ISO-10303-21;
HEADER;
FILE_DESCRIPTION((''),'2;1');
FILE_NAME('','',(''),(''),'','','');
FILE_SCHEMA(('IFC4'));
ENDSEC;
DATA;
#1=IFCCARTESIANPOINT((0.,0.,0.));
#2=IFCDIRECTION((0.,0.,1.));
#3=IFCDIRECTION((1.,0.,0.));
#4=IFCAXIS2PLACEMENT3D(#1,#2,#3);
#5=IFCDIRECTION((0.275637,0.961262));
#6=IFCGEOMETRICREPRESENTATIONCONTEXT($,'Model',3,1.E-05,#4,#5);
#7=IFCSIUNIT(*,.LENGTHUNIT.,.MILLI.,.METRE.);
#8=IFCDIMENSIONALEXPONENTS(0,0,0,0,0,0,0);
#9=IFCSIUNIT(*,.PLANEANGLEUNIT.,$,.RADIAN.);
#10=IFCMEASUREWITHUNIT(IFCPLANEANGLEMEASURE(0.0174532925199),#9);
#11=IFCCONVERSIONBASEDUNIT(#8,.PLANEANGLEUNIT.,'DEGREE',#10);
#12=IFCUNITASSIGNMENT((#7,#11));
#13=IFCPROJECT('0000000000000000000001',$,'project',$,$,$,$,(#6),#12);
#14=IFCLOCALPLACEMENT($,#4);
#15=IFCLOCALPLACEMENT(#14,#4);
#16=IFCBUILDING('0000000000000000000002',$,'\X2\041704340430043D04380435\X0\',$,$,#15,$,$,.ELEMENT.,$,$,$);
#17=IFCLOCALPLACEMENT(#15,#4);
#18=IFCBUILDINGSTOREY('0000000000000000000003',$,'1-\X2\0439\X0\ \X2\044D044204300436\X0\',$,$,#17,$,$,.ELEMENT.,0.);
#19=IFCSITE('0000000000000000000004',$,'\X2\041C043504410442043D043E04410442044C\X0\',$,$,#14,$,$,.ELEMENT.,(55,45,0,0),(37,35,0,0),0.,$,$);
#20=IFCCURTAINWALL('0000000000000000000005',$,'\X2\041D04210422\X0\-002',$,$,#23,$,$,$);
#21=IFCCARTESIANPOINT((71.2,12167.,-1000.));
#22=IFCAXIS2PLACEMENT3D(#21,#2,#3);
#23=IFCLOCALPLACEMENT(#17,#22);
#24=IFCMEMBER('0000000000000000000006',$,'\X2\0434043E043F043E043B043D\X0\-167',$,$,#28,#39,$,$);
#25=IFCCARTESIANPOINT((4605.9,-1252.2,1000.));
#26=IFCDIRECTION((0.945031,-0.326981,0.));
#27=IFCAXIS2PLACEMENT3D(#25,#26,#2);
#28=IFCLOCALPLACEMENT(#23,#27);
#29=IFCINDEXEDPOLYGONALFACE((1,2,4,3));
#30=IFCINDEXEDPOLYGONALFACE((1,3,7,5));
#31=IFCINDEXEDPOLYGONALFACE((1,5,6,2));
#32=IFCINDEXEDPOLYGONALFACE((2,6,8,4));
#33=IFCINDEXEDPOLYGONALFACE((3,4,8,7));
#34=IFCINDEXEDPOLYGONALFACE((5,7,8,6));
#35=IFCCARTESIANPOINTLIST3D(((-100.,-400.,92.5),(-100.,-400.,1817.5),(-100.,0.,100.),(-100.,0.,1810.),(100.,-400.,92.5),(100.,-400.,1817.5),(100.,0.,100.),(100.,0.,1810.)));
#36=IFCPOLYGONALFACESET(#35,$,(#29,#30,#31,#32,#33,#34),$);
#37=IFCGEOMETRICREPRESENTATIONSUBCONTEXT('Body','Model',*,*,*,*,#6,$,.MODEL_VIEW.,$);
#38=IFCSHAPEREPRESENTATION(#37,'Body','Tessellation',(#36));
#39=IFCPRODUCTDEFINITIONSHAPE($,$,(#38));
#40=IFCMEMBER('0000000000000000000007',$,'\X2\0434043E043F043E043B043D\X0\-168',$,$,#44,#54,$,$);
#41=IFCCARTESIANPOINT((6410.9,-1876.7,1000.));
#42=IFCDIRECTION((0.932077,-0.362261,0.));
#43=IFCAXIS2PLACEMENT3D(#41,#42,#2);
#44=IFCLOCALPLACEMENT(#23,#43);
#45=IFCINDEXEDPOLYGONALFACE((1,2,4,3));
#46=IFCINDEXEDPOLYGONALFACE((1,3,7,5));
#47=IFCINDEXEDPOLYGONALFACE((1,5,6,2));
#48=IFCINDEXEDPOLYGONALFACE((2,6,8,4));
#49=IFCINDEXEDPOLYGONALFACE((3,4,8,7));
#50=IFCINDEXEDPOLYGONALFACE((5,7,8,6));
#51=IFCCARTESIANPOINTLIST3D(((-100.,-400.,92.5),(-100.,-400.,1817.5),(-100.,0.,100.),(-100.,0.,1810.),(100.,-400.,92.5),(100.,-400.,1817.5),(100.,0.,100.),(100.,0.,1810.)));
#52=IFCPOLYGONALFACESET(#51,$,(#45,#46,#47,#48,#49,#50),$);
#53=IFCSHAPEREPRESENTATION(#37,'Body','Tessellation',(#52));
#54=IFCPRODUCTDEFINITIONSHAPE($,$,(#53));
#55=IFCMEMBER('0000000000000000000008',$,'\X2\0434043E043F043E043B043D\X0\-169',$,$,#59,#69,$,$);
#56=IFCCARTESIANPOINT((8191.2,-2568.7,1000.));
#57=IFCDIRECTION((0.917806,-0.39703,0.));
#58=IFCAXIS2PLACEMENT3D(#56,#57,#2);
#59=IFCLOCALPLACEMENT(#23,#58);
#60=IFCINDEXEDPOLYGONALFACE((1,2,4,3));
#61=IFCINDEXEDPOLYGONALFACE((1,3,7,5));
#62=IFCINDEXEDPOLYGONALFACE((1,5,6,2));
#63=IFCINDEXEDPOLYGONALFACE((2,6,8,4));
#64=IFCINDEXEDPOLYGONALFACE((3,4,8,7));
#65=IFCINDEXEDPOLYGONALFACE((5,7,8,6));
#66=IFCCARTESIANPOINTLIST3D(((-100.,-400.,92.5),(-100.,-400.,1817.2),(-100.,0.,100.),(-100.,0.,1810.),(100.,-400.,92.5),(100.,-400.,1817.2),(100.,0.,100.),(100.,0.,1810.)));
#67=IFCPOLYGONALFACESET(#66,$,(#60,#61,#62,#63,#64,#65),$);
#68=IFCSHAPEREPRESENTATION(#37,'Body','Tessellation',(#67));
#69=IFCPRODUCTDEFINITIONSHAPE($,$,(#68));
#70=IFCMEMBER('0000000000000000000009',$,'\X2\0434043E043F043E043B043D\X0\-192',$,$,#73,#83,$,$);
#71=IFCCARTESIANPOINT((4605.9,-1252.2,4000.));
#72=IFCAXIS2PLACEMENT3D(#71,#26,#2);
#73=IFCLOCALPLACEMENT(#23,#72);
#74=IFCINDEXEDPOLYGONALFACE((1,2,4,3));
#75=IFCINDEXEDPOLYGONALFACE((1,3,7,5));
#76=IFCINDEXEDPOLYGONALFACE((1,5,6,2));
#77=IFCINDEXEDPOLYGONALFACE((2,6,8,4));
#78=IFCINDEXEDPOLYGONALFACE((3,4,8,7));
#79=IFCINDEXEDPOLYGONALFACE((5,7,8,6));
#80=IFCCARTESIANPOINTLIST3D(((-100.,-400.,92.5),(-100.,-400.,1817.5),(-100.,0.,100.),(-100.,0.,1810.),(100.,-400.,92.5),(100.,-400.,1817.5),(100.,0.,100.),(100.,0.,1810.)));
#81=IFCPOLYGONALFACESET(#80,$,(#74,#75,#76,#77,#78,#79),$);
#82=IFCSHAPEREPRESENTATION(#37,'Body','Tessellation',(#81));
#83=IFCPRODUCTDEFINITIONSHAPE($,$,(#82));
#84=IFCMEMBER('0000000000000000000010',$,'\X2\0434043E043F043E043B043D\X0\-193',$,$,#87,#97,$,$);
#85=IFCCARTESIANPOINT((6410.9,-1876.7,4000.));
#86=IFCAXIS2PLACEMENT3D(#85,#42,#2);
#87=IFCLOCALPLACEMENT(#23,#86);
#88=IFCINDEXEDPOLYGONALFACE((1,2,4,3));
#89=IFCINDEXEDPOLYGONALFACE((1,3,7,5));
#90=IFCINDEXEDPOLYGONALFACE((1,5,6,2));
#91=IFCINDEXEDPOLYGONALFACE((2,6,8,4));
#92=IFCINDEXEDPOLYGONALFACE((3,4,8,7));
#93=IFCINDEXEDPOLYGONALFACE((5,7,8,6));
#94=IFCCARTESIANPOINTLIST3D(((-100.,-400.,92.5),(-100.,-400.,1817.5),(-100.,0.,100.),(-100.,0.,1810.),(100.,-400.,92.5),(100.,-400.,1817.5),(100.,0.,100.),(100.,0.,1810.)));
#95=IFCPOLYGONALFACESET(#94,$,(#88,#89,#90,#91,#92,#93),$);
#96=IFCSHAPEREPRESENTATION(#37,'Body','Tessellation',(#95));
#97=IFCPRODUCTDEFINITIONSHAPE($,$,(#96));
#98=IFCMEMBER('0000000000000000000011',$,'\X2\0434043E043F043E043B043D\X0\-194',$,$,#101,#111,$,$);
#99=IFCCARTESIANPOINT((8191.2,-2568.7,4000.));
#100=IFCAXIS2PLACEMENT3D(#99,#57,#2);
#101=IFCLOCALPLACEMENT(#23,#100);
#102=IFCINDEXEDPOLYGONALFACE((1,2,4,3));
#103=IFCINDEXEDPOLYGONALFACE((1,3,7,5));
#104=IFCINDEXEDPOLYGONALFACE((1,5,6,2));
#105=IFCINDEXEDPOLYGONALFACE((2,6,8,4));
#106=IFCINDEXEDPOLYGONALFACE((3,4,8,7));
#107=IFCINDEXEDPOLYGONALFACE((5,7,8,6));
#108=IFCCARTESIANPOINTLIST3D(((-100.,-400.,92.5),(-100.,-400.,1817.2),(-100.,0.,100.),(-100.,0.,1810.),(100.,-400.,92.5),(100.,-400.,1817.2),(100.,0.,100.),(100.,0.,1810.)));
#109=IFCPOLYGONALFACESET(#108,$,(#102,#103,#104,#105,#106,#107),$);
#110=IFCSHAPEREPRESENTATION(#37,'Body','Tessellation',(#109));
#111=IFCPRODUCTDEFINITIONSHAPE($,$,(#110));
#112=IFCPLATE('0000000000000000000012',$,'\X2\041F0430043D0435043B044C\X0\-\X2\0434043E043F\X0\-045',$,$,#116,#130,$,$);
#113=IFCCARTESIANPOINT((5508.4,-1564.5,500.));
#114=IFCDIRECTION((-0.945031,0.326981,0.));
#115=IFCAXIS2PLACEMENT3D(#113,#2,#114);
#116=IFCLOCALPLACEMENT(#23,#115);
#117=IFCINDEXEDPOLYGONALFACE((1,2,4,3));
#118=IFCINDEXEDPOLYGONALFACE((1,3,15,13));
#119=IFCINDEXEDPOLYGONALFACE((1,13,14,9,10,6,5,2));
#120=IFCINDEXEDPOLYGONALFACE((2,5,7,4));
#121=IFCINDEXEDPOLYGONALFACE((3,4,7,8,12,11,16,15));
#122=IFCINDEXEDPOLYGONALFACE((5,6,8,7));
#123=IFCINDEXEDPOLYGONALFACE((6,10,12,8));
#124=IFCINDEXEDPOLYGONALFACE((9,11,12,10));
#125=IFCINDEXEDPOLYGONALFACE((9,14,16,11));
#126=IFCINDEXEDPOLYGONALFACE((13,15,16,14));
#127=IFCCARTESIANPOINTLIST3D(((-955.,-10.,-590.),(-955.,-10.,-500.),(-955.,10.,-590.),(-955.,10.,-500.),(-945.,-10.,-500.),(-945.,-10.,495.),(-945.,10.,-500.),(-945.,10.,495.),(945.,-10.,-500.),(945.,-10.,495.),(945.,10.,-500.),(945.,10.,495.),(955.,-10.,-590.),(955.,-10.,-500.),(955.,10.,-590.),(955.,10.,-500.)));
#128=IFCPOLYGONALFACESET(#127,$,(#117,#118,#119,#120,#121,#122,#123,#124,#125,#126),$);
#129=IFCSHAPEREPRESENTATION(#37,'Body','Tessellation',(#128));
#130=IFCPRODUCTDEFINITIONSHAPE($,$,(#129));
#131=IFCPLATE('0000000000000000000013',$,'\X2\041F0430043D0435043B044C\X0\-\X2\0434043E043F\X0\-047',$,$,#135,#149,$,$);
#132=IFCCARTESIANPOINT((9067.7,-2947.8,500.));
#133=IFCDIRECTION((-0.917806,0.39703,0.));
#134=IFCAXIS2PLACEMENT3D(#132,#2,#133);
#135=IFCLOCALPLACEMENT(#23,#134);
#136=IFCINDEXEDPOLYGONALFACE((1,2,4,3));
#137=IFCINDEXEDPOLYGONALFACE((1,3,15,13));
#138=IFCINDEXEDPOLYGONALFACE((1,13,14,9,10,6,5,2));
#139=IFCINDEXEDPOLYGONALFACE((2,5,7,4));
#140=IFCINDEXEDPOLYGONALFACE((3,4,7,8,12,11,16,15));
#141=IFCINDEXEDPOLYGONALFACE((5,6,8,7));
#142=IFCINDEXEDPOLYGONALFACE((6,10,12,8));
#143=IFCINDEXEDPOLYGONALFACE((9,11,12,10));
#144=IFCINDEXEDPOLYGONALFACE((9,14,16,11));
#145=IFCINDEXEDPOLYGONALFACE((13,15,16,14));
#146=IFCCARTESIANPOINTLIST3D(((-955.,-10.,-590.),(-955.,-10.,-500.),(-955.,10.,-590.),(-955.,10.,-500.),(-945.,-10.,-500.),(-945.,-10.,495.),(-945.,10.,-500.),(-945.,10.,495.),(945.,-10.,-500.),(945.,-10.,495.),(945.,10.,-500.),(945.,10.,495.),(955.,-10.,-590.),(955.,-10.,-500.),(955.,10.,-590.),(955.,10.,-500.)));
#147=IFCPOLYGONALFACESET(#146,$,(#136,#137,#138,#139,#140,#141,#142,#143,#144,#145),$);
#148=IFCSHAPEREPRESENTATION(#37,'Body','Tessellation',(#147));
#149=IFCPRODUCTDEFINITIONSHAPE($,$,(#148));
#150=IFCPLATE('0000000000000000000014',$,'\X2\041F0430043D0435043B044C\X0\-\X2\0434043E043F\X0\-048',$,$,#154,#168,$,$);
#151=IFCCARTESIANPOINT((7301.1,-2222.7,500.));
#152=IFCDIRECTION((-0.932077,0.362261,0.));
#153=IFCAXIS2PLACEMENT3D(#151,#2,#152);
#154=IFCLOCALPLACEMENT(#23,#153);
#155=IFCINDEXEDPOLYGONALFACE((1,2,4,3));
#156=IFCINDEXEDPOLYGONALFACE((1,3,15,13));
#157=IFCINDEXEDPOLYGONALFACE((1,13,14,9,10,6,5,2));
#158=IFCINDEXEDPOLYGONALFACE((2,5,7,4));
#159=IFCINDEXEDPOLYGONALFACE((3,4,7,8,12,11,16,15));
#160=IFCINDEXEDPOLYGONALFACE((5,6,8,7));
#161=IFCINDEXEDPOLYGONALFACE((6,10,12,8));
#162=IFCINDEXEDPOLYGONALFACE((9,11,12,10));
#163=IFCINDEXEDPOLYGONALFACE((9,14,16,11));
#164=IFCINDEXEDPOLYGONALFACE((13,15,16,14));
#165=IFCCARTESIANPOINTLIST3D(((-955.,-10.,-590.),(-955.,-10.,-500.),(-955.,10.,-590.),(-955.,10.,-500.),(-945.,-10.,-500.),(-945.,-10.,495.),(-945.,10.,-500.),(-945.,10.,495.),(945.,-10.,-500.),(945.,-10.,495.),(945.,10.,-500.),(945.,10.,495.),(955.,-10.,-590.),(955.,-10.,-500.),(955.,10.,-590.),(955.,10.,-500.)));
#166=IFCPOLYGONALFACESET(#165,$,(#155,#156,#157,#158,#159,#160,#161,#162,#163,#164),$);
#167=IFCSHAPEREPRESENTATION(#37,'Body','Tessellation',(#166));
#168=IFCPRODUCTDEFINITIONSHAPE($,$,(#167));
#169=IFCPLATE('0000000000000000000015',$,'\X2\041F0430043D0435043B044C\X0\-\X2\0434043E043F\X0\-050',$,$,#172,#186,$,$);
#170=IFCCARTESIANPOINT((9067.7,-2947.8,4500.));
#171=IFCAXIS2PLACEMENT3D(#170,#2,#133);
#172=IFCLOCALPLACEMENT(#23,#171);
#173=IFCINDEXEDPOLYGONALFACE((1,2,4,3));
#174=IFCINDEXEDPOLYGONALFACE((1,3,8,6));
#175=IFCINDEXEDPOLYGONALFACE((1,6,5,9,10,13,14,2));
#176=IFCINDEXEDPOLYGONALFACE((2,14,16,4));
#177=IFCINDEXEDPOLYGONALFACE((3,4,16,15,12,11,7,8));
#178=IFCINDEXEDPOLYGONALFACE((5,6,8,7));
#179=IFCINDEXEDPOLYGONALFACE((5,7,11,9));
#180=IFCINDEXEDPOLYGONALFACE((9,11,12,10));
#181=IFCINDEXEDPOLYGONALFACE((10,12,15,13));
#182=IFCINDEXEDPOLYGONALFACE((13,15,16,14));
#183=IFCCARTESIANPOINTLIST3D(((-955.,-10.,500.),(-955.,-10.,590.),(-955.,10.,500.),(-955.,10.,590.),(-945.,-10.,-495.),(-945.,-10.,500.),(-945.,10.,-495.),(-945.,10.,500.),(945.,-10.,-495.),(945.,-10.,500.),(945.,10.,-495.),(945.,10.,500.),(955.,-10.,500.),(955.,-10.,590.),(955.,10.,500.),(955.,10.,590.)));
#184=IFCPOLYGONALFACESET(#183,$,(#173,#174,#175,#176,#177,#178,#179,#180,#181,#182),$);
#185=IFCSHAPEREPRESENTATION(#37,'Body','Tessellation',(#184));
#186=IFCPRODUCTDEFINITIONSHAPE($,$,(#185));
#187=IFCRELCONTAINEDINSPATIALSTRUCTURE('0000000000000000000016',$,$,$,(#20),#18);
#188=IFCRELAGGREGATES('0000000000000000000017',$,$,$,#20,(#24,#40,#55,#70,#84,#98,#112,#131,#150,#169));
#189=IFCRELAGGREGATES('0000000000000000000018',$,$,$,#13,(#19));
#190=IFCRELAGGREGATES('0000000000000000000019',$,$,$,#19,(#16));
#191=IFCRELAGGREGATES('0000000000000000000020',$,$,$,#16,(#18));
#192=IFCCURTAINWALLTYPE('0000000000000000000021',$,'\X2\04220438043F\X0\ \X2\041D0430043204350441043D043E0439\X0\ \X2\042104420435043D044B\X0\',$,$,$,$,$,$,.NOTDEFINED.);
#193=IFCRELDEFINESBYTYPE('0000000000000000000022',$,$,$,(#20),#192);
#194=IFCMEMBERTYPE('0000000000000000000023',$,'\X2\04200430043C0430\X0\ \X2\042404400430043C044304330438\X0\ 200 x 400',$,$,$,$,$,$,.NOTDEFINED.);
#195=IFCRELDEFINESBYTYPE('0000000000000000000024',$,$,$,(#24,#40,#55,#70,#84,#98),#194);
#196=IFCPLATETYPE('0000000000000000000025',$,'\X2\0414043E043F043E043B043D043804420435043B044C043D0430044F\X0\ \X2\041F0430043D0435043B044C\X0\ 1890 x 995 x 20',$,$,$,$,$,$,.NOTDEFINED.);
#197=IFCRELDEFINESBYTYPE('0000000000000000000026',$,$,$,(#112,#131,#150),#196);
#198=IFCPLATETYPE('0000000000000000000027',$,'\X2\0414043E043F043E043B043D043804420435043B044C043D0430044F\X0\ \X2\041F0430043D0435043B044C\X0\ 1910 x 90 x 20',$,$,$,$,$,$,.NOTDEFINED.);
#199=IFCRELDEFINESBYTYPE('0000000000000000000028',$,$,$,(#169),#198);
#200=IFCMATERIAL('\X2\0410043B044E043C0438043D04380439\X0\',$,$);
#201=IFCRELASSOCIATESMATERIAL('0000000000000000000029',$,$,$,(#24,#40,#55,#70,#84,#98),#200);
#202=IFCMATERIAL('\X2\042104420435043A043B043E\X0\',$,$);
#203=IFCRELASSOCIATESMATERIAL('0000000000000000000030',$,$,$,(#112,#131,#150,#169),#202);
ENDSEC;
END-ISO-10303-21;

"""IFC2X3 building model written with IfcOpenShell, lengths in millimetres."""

from ifc_helpers import new_model, entity, si_unit, converted_unit, direction, frame, origin_with_axes, place, context, subcontext, project, spatial, polyline, outline, extrude, clip, halfspace, material, type_object, element, aggregate, save


model = new_model("IFC2X3")

# Units and contexts
model_context = context("Model", 3, precision=1e-05, world=origin_with_axes(), true_north=direction((0.275637, 0.961262)))
body_context = subcontext(model_context, "Body", "Model", "MODEL_VIEW")
ifc_project = project(units=[si_unit("LENGTHUNIT", "METRE", prefix="MILLI"), converted_unit("PLANEANGLEUNIT", "DEGREE", entity("IfcPlaneAngleMeasure", 0.0174532925199), si_unit("PLANEANGLEUNIT", "RADIAN"), dimensions=[0, 0, 0, 0, 0, 0, 0])], contexts=[model_context])

# Site, building, storey
site_placement = place(None, origin_with_axes())
site = spatial("IfcSite", under=ifc_project, at=site_placement, Name="Местность", CompositionType="ELEMENT", RefLatitude=(55, 45, 0, 0), RefLongitude=(37, 35, 0, 0), RefElevation=0.0)
building_placement = place(site_placement, origin_with_axes())
building = spatial("IfcBuilding", under=site, at=building_placement, Name="Здание", CompositionType="ELEMENT")
storey_placement = place(building_placement, origin_with_axes())
storey = spatial("IfcBuildingStorey", under=building, at=storey_placement, Name="1-й этаж", CompositionType="ELEMENT", Elevation=0.0)

# Curtain wall, members, plates
curtain_wall_type = type_object("IfcCurtainWallType", Name="Тип Навесной Стены", PredefinedType="NOTDEFINED")
curtain_wall_placement = place(storey_placement, frame((71.2, 12167.0, -1000.0), z_axis=(0.0, 0.0, 1.0), x_axis=(1.0, 0.0, 0.0)))
curtain_wall = element("IfcCurtainWall", 1, at=curtain_wall_placement, inside=storey, type_object=curtain_wall_type, Name="НСТ-002")
ifc_material_1 = material(Name="Алюминий")
member_type_1 = type_object("IfcMemberType", Name="Рама Фрамуги 200 x 400", PredefinedType="NOTDEFINED")
member_1_placement = place(curtain_wall_placement, frame((4605.9, -1252.2, 1000.0), z_axis=(0.945031, -0.326981, 0.0), x_axis=(0.0, 0.0, 1.0)))
member_1 = element("IfcMember", 2, at=member_1_placement, type_object=member_type_1, material=ifc_material_1, Name="дополн-167", context=body_context, shape_type="Clipping", body=[
    clip(clip(extrude(outline(polyline([(-400.0, -100.0), (0.0, -100.0), (0.0, 100.0), (-400.0, 100.0), (-400.0, -100.0)])), frame((0.0, 0.0, 92.5), z_axis=(0.0, 0.0, 1.0), x_axis=(0.0, 1.0, 0.0)), (0.0, 0.0, 1.0), 1725.0), halfspace(frame((0.0, 34.0, 1809.3), z_axis=(0.0, -0.018792, -0.999823), x_axis=(0.0, 0.999823, -0.018792)), True)), halfspace(frame((0.0, -1.9, 100.0), z_axis=(0.0, -0.018792, 0.999823), x_axis=(0.0, -0.999823, -0.018792)), True)),
])
member_2_placement = place(curtain_wall_placement, frame((6410.9, -1876.7, 1000.0), z_axis=(0.932077, -0.362261, 0.0), x_axis=(0.0, 0.0, 1.0)))
member_2 = element("IfcMember", 3, at=member_2_placement, type_object=member_type_1, material=ifc_material_1, Name="дополн-168", context=body_context, shape_type="Clipping", body=[
    clip(clip(extrude(outline(polyline([(-400.0, -100.0), (0.0, -100.0), (0.0, 100.0), (-400.0, 100.0), (-400.0, -100.0)])), frame((0.0, 0.0, 92.5), z_axis=(0.0, 0.0, 1.0), x_axis=(0.0, 1.0, 0.0)), (0.0, 0.0, 1.0), 1725.0), halfspace(frame((0.0, 34.0, 1809.3), z_axis=(0.0, -0.018792, -0.999823), x_axis=(0.0, 0.999823, -0.018792)), True)), halfspace(frame((0.0, -1.9, 100.0), z_axis=(0.0, -0.018792, 0.999823), x_axis=(0.0, -0.999823, -0.018792)), True)),
])
member_3_placement = place(curtain_wall_placement, frame((8191.2, -2568.7, 1000.0), z_axis=(0.917806, -0.39703, 0.0), x_axis=(0.0, 0.0, 1.0)))
member_3 = element("IfcMember", 4, at=member_3_placement, type_object=member_type_1, material=ifc_material_1, Name="дополн-169", context=body_context, shape_type="Clipping", body=[
    clip(clip(extrude(outline(polyline([(-400.0, -100.0), (0.0, -100.0), (0.0, 100.0), (-400.0, 100.0), (-400.0, -100.0)])), frame((0.0, 0.0, 92.5), z_axis=(0.0, 0.0, 1.0), x_axis=(0.0, 1.0, 0.0)), (0.0, 0.0, 1.0), 1724.6), halfspace(frame((0.0, 32.5, 1809.4), z_axis=(0.0, -0.017986, -0.999838), x_axis=(0.0, 0.999838, -0.017986)), True)), halfspace(frame((0.0, -1.9, 100.0), z_axis=(0.0, -0.018792, 0.999823), x_axis=(0.0, -0.999823, -0.018792)), True)),
])
member_4_placement = place(curtain_wall_placement, frame((4605.9, -1252.2, 4000.0), z_axis=(0.945031, -0.326981, 0.0), x_axis=(0.0, 0.0, 1.0)))
member_4 = element("IfcMember", 5, at=member_4_placement, type_object=member_type_1, material=ifc_material_1, Name="дополн-192", context=body_context, shape_type="Clipping", body=[
    clip(clip(extrude(outline(polyline([(-400.0, -100.0), (0.0, -100.0), (0.0, 100.0), (-400.0, 100.0), (-400.0, -100.0)])), frame((0.0, 0.0, 92.5), z_axis=(0.0, 0.0, 1.0), x_axis=(0.0, 1.0, 0.0)), (0.0, 0.0, 1.0), 1725.0), halfspace(frame((0.0, 34.0, 1809.3), z_axis=(0.0, -0.018792, -0.999823), x_axis=(0.0, 0.999823, -0.018792)), True)), halfspace(frame((0.0, -1.9, 100.0), z_axis=(0.0, -0.018792, 0.999823), x_axis=(0.0, -0.999823, -0.018792)), True)),
])
member_5_placement = place(curtain_wall_placement, frame((6410.9, -1876.7, 4000.0), z_axis=(0.932077, -0.362261, 0.0), x_axis=(0.0, 0.0, 1.0)))
member_5 = element("IfcMember", 6, at=member_5_placement, type_object=member_type_1, material=ifc_material_1, Name="дополн-193", context=body_context, shape_type="Clipping", body=[
    clip(clip(extrude(outline(polyline([(-400.0, -100.0), (0.0, -100.0), (0.0, 100.0), (-400.0, 100.0), (-400.0, -100.0)])), frame((0.0, 0.0, 92.5), z_axis=(0.0, 0.0, 1.0), x_axis=(0.0, 1.0, 0.0)), (0.0, 0.0, 1.0), 1725.0), halfspace(frame((0.0, 34.0, 1809.3), z_axis=(0.0, -0.018792, -0.999823), x_axis=(0.0, 0.999823, -0.018792)), True)), halfspace(frame((0.0, -1.9, 100.0), z_axis=(0.0, -0.018792, 0.999823), x_axis=(0.0, -0.999823, -0.018792)), True)),
])
member_6_placement = place(curtain_wall_placement, frame((8191.2, -2568.7, 4000.0), z_axis=(0.917806, -0.39703, 0.0), x_axis=(0.0, 0.0, 1.0)))
member_6 = element("IfcMember", 7, at=member_6_placement, type_object=member_type_1, material=ifc_material_1, Name="дополн-194", context=body_context, shape_type="Clipping", body=[
    clip(clip(extrude(outline(polyline([(-400.0, -100.0), (0.0, -100.0), (0.0, 100.0), (-400.0, 100.0), (-400.0, -100.0)])), frame((0.0, 0.0, 92.5), z_axis=(0.0, 0.0, 1.0), x_axis=(0.0, 1.0, 0.0)), (0.0, 0.0, 1.0), 1724.6), halfspace(frame((0.0, 32.5, 1809.4), z_axis=(0.0, -0.017986, -0.999838), x_axis=(0.0, 0.999838, -0.017986)), True)), halfspace(frame((0.0, -1.9, 100.0), z_axis=(0.0, -0.018792, 0.999823), x_axis=(0.0, -0.999823, -0.018792)), True)),
])
ifc_material_2 = material(Name="Стекло")
plate_type_1 = type_object("IfcPlateType", Name="Дополнительная Панель 1890 x 995 x 20", PredefinedType="NOTDEFINED")
plate_1_placement = place(curtain_wall_placement, frame((5508.4, -1564.5, 500.0), z_axis=(0.0, 0.0, 1.0), x_axis=(-0.945031, 0.326981, 0.0)))
plate_1 = element("IfcPlate", 8, at=plate_1_placement, type_object=plate_type_1, material=ifc_material_2, Name="Панель-доп-045", context=body_context, shape_type="SweptSolid", body=[
    extrude(outline(polyline([(-945.0, -495.0), (945.0, -495.0), (945.0, 500.0), (955.0, 500.0), (955.0, 590.0), (-955.0, 590.0), (-955.0, 500.0), (-945.0, 500.0), (-945.0, -495.0)])), frame((0.0, -10.0, 0.0), z_axis=(0.0, 1.0, 0.0), x_axis=(1.0, 0.0, 0.0)), (0.0, 0.0, 1.0), 20.0),
])
plate_2_placement = place(curtain_wall_placement, frame((9067.7, -2947.8, 500.0), z_axis=(0.0, 0.0, 1.0), x_axis=(-0.917806, 0.39703, 0.0)))
plate_2 = element("IfcPlate", 9, at=plate_2_placement, type_object=plate_type_1, material=ifc_material_2, Name="Панель-доп-047", context=body_context, shape_type="SweptSolid", body=[
    extrude(outline(polyline([(-945.0, -495.0), (945.0, -495.0), (945.0, 500.0), (955.0, 500.0), (955.0, 590.0), (-955.0, 590.0), (-955.0, 500.0), (-945.0, 500.0), (-945.0, -495.0)])), frame((0.0, -10.0, 0.0), z_axis=(0.0, 1.0, 0.0), x_axis=(1.0, 0.0, 0.0)), (0.0, 0.0, 1.0), 20.0),
])
plate_3_placement = place(curtain_wall_placement, frame((7301.1, -2222.7, 500.0), z_axis=(0.0, 0.0, 1.0), x_axis=(-0.932077, 0.362261, 0.0)))
plate_3 = element("IfcPlate", 10, at=plate_3_placement, type_object=plate_type_1, material=ifc_material_2, Name="Панель-доп-048", context=body_context, shape_type="SweptSolid", body=[
    extrude(outline(polyline([(-945.0, -495.0), (945.0, -495.0), (945.0, 500.0), (955.0, 500.0), (955.0, 590.0), (-955.0, 590.0), (-955.0, 500.0), (-945.0, 500.0), (-945.0, -495.0)])), frame((0.0, -10.0, 0.0), z_axis=(0.0, 1.0, 0.0), x_axis=(1.0, 0.0, 0.0)), (0.0, 0.0, 1.0), 20.0),
])
plate_type_2 = type_object("IfcPlateType", Name="Дополнительная Панель 1910 x 90 x 20", PredefinedType="NOTDEFINED")
plate_4_placement = place(curtain_wall_placement, frame((9067.7, -2947.8, 4500.0), z_axis=(0.0, 0.0, 1.0), x_axis=(-0.917806, 0.39703, 0.0)))
plate_4 = element("IfcPlate", 11, at=plate_4_placement, type_object=plate_type_2, material=ifc_material_2, Name="Панель-доп-050", context=body_context, shape_type="SweptSolid", body=[
    extrude(outline(polyline([(-955.0, -590.0), (955.0, -590.0), (955.0, -500.0), (945.0, -500.0), (945.0, 495.0), (-945.0, 495.0), (-945.0, -500.0), (-955.0, -500.0), (-955.0, -590.0)])), frame((0.0, -10.0, 0.0), z_axis=(0.0, 1.0, 0.0), x_axis=(1.0, 0.0, 0.0)), (0.0, 0.0, 1.0), 20.0),
])
aggregate(curtain_wall, [member_1, member_2, member_3, member_4, member_5, member_6, plate_1, plate_2, plate_3, plate_4])

save(model, "model.ifc")
